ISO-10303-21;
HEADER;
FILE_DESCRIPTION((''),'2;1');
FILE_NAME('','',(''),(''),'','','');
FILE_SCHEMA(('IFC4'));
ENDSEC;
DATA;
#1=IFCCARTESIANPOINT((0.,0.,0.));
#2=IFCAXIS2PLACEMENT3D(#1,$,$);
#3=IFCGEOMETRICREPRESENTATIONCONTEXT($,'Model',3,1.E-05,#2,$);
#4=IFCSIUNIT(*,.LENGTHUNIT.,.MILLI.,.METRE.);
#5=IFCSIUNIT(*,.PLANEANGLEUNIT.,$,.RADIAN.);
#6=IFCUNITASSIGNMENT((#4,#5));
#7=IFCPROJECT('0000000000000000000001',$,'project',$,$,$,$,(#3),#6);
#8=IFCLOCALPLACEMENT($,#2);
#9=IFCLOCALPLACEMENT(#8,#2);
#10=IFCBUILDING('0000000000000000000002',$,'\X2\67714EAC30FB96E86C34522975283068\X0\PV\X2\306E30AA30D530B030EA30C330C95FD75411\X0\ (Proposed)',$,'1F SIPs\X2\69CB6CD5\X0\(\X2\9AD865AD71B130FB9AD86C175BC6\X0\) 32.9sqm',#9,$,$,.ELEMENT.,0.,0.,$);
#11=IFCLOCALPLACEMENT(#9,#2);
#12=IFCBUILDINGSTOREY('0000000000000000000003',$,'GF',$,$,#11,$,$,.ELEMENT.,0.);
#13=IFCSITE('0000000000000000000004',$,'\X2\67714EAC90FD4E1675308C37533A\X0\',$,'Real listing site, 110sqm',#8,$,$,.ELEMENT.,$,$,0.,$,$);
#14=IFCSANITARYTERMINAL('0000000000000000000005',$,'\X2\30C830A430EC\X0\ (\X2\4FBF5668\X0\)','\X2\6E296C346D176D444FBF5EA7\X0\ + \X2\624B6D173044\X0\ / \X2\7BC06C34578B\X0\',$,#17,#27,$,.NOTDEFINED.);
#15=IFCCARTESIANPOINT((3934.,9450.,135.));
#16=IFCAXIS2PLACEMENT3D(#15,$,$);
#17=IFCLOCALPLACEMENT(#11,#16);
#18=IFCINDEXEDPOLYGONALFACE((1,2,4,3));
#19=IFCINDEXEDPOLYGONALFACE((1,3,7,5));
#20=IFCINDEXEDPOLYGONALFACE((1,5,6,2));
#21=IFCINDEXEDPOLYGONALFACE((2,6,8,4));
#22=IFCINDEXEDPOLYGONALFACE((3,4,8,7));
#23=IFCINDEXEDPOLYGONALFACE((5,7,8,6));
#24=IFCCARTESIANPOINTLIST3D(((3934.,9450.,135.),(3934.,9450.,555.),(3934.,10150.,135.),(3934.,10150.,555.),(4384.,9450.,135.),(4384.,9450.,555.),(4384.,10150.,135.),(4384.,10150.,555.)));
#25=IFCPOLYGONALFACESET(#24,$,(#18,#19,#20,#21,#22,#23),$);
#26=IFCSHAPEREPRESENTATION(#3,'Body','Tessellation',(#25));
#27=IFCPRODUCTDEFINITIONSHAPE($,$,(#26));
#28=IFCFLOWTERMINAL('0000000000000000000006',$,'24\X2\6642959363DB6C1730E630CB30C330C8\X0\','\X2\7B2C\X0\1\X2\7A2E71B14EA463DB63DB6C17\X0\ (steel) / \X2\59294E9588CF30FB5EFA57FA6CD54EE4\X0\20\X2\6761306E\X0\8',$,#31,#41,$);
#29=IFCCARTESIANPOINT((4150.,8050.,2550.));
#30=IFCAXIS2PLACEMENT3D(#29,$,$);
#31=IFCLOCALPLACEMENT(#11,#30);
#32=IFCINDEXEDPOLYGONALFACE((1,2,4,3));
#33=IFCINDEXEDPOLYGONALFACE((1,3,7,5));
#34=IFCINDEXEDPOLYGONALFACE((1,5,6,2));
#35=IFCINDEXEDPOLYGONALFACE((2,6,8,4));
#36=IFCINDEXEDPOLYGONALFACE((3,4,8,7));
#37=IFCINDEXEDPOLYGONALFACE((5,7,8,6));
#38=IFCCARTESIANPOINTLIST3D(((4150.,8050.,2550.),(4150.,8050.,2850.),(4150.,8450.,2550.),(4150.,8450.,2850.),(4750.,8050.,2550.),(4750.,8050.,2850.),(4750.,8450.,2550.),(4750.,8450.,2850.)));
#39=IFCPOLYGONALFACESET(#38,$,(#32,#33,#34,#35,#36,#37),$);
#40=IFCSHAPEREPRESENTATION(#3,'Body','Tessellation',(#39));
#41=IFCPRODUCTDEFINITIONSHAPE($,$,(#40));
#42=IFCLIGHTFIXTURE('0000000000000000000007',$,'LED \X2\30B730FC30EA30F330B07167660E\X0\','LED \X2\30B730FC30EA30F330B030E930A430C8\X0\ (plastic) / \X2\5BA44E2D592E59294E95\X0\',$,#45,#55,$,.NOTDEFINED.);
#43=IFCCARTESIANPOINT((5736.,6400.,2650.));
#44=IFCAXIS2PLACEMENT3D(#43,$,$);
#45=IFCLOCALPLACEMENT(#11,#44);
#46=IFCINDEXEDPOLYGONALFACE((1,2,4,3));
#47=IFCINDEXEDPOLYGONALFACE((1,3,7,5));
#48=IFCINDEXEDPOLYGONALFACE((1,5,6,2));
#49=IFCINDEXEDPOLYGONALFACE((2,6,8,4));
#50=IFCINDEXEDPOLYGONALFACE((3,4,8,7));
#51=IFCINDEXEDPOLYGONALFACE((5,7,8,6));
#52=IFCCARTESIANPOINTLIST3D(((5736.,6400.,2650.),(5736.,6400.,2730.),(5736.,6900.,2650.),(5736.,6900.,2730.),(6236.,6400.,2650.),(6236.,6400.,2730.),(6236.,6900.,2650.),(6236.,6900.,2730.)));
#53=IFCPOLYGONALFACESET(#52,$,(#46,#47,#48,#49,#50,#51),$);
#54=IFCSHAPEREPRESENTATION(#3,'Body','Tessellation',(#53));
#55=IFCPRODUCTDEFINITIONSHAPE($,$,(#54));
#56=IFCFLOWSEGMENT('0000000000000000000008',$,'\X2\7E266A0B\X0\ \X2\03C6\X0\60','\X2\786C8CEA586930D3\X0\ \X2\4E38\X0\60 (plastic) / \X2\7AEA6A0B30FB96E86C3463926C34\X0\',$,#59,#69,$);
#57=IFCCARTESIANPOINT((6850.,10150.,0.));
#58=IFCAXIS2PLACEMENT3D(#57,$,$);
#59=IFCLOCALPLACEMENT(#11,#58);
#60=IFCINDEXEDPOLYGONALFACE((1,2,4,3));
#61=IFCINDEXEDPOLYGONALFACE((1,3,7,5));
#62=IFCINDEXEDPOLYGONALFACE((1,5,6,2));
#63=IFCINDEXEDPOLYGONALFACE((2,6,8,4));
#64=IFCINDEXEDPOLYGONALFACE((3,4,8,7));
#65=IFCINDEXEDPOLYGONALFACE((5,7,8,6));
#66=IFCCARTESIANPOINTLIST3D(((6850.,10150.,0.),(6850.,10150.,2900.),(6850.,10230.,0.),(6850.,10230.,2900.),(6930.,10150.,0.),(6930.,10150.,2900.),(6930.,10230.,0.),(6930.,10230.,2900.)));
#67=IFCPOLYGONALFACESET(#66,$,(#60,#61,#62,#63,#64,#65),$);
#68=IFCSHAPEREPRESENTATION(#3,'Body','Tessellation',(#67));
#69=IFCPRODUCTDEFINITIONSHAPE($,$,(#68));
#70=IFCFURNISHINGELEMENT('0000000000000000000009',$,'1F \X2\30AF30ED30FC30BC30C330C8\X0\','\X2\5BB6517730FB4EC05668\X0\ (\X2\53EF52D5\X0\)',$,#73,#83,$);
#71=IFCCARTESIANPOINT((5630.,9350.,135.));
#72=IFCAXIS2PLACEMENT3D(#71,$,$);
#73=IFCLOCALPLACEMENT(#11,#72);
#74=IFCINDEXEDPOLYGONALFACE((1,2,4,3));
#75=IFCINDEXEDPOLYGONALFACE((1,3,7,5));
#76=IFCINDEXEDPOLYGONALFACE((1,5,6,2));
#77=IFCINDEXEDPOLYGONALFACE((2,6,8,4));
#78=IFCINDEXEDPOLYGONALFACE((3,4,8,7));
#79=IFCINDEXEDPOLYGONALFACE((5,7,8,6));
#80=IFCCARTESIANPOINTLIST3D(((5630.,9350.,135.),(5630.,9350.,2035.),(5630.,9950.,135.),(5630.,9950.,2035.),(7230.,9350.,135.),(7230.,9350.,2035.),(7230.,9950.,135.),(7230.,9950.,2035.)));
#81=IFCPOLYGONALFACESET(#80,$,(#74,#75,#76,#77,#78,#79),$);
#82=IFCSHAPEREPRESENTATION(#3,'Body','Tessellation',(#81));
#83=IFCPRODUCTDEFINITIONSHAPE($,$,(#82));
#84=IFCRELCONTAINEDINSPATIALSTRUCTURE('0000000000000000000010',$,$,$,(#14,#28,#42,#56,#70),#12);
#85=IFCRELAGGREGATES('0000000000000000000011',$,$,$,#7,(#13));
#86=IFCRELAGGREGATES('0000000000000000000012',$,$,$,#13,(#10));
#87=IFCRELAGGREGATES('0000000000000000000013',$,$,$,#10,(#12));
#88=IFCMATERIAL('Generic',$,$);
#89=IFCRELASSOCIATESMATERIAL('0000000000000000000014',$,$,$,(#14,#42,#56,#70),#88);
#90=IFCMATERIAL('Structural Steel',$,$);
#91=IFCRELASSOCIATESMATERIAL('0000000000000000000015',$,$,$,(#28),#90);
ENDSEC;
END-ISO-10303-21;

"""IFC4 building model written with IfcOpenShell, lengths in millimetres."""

from ifc_helpers import new_model, si_unit, frame, frame_2d, origin, place, context, project, spatial, rectangle, extrude, material, element, save


model = new_model("IFC4")

# Units and contexts
model_context = context("Model", 3, precision=1e-05, world=origin())
ifc_project = project(units=[si_unit("LENGTHUNIT", "METRE", prefix="MILLI"), si_unit("PLANEANGLEUNIT", "RADIAN")], contexts=[model_context])

# Site, building, storey
site_placement = place(None, origin())
site = spatial("IfcSite", under=ifc_project, at=site_placement, Name="東京都世田谷区", ObjectType="Real listing site, 110sqm", CompositionType="ELEMENT", RefElevation=0.0)
building_placement = place(site_placement, origin())
building = spatial("IfcBuilding", under=site, at=building_placement, Name="東京・雨水利用とPVのオフグリッド志向 (Proposed)", ObjectType="1F SIPs構法(高断熱・高気密) 32.9sqm", CompositionType="ELEMENT", ElevationOfRefHeight=0.0, ElevationOfTerrain=0.0)
storey_placement = place(building_placement, origin())
storey = spatial("IfcBuildingStorey", under=building, at=storey_placement, Name="GF", CompositionType="ELEMENT", Elevation=0.0)

# Shared definitions
ifc_material_1 = material(Name="Generic")

# Sanitary terminal
sanitary_terminal_placement = place(storey_placement, frame((3934.0, 9450.0, 135.0)))
element("IfcSanitaryTerminal", 1, at=sanitary_terminal_placement, inside=storey, material=ifc_material_1, Name="トイレ (便器)", Description="温水洗浄便座 + 手洗い / 節水型", PredefinedType="NOTDEFINED", context=model_context, shape_type="SweptSolid", body=[
    extrude(rectangle(XDim=450.0, YDim=700.0, at=frame_2d((225.0, 350.0))), frame((3934.0, 9450.0, 135.0)), (0.0, 0.0, 1.0), 420.0),
])

# Flow terminal
ifc_material_2 = material(Name="Structural Steel")
flow_terminal_placement = place(storey_placement, frame((4150.0, 8050.0, 2550.0)))
element("IfcFlowTerminal", 2, at=flow_terminal_placement, inside=storey, material=ifc_material_2, Name="24時間換気ユニット", Description="第1種熱交換換気 (steel) / 天井裏・建基法令20条の8", context=model_context, shape_type="SweptSolid", body=[
    extrude(rectangle(XDim=600.0, YDim=400.0, at=frame_2d((300.0, 200.0))), frame((4150.0, 8050.0, 2550.0)), (0.0, 0.0, 1.0), 300.0),
])

# Light fixture
light_fixture_placement = place(storey_placement, frame((5736.0, 6400.0, 2650.0)))
element("IfcLightFixture", 3, at=light_fixture_placement, inside=storey, material=ifc_material_1, Name="LED シーリング照明", Description="LED シーリングライト (plastic) / 室中央天井", PredefinedType="NOTDEFINED", context=model_context, shape_type="SweptSolid", body=[
    extrude(rectangle(XDim=500.0, YDim=500.0, at=frame_2d((250.0, 250.0))), frame((5736.0, 6400.0, 2650.0)), (0.0, 0.0, 1.0), 80.0),
])

# Flow segment
flow_segment_placement = place(storey_placement, frame((6850.0, 10150.0, 0.0)))
element("IfcFlowSegment", 4, at=flow_segment_placement, inside=storey, material=ifc_material_1, Name="縦樋 φ60", Description="硬質塩ビ 丸60 (plastic) / 竪樋・雨水排水", context=model_context, shape_type="SweptSolid", body=[
    extrude(rectangle(XDim=80.0, YDim=80.0, at=frame_2d((40.0, 40.0))), frame((6850.0, 10150.0, 0.0)), (0.0, 0.0, 1.0), 2900.0),
])

# Furnishing element
furnishing_placement = place(storey_placement, frame((5630.0, 9350.0, 135.0)))
element("IfcFurnishingElement", 5, at=furnishing_placement, inside=storey, material=ifc_material_1, Name="1F クローゼット", Description="家具・什器 (可動)", context=model_context, shape_type="SweptSolid", body=[
    extrude(rectangle(XDim=1600.0, YDim=600.0, at=frame_2d((800.0, 300.0))), frame((5630.0, 9350.0, 135.0)), (0.0, 0.0, 1.0), 1900.0),
])

save(model, "model.ifc")
